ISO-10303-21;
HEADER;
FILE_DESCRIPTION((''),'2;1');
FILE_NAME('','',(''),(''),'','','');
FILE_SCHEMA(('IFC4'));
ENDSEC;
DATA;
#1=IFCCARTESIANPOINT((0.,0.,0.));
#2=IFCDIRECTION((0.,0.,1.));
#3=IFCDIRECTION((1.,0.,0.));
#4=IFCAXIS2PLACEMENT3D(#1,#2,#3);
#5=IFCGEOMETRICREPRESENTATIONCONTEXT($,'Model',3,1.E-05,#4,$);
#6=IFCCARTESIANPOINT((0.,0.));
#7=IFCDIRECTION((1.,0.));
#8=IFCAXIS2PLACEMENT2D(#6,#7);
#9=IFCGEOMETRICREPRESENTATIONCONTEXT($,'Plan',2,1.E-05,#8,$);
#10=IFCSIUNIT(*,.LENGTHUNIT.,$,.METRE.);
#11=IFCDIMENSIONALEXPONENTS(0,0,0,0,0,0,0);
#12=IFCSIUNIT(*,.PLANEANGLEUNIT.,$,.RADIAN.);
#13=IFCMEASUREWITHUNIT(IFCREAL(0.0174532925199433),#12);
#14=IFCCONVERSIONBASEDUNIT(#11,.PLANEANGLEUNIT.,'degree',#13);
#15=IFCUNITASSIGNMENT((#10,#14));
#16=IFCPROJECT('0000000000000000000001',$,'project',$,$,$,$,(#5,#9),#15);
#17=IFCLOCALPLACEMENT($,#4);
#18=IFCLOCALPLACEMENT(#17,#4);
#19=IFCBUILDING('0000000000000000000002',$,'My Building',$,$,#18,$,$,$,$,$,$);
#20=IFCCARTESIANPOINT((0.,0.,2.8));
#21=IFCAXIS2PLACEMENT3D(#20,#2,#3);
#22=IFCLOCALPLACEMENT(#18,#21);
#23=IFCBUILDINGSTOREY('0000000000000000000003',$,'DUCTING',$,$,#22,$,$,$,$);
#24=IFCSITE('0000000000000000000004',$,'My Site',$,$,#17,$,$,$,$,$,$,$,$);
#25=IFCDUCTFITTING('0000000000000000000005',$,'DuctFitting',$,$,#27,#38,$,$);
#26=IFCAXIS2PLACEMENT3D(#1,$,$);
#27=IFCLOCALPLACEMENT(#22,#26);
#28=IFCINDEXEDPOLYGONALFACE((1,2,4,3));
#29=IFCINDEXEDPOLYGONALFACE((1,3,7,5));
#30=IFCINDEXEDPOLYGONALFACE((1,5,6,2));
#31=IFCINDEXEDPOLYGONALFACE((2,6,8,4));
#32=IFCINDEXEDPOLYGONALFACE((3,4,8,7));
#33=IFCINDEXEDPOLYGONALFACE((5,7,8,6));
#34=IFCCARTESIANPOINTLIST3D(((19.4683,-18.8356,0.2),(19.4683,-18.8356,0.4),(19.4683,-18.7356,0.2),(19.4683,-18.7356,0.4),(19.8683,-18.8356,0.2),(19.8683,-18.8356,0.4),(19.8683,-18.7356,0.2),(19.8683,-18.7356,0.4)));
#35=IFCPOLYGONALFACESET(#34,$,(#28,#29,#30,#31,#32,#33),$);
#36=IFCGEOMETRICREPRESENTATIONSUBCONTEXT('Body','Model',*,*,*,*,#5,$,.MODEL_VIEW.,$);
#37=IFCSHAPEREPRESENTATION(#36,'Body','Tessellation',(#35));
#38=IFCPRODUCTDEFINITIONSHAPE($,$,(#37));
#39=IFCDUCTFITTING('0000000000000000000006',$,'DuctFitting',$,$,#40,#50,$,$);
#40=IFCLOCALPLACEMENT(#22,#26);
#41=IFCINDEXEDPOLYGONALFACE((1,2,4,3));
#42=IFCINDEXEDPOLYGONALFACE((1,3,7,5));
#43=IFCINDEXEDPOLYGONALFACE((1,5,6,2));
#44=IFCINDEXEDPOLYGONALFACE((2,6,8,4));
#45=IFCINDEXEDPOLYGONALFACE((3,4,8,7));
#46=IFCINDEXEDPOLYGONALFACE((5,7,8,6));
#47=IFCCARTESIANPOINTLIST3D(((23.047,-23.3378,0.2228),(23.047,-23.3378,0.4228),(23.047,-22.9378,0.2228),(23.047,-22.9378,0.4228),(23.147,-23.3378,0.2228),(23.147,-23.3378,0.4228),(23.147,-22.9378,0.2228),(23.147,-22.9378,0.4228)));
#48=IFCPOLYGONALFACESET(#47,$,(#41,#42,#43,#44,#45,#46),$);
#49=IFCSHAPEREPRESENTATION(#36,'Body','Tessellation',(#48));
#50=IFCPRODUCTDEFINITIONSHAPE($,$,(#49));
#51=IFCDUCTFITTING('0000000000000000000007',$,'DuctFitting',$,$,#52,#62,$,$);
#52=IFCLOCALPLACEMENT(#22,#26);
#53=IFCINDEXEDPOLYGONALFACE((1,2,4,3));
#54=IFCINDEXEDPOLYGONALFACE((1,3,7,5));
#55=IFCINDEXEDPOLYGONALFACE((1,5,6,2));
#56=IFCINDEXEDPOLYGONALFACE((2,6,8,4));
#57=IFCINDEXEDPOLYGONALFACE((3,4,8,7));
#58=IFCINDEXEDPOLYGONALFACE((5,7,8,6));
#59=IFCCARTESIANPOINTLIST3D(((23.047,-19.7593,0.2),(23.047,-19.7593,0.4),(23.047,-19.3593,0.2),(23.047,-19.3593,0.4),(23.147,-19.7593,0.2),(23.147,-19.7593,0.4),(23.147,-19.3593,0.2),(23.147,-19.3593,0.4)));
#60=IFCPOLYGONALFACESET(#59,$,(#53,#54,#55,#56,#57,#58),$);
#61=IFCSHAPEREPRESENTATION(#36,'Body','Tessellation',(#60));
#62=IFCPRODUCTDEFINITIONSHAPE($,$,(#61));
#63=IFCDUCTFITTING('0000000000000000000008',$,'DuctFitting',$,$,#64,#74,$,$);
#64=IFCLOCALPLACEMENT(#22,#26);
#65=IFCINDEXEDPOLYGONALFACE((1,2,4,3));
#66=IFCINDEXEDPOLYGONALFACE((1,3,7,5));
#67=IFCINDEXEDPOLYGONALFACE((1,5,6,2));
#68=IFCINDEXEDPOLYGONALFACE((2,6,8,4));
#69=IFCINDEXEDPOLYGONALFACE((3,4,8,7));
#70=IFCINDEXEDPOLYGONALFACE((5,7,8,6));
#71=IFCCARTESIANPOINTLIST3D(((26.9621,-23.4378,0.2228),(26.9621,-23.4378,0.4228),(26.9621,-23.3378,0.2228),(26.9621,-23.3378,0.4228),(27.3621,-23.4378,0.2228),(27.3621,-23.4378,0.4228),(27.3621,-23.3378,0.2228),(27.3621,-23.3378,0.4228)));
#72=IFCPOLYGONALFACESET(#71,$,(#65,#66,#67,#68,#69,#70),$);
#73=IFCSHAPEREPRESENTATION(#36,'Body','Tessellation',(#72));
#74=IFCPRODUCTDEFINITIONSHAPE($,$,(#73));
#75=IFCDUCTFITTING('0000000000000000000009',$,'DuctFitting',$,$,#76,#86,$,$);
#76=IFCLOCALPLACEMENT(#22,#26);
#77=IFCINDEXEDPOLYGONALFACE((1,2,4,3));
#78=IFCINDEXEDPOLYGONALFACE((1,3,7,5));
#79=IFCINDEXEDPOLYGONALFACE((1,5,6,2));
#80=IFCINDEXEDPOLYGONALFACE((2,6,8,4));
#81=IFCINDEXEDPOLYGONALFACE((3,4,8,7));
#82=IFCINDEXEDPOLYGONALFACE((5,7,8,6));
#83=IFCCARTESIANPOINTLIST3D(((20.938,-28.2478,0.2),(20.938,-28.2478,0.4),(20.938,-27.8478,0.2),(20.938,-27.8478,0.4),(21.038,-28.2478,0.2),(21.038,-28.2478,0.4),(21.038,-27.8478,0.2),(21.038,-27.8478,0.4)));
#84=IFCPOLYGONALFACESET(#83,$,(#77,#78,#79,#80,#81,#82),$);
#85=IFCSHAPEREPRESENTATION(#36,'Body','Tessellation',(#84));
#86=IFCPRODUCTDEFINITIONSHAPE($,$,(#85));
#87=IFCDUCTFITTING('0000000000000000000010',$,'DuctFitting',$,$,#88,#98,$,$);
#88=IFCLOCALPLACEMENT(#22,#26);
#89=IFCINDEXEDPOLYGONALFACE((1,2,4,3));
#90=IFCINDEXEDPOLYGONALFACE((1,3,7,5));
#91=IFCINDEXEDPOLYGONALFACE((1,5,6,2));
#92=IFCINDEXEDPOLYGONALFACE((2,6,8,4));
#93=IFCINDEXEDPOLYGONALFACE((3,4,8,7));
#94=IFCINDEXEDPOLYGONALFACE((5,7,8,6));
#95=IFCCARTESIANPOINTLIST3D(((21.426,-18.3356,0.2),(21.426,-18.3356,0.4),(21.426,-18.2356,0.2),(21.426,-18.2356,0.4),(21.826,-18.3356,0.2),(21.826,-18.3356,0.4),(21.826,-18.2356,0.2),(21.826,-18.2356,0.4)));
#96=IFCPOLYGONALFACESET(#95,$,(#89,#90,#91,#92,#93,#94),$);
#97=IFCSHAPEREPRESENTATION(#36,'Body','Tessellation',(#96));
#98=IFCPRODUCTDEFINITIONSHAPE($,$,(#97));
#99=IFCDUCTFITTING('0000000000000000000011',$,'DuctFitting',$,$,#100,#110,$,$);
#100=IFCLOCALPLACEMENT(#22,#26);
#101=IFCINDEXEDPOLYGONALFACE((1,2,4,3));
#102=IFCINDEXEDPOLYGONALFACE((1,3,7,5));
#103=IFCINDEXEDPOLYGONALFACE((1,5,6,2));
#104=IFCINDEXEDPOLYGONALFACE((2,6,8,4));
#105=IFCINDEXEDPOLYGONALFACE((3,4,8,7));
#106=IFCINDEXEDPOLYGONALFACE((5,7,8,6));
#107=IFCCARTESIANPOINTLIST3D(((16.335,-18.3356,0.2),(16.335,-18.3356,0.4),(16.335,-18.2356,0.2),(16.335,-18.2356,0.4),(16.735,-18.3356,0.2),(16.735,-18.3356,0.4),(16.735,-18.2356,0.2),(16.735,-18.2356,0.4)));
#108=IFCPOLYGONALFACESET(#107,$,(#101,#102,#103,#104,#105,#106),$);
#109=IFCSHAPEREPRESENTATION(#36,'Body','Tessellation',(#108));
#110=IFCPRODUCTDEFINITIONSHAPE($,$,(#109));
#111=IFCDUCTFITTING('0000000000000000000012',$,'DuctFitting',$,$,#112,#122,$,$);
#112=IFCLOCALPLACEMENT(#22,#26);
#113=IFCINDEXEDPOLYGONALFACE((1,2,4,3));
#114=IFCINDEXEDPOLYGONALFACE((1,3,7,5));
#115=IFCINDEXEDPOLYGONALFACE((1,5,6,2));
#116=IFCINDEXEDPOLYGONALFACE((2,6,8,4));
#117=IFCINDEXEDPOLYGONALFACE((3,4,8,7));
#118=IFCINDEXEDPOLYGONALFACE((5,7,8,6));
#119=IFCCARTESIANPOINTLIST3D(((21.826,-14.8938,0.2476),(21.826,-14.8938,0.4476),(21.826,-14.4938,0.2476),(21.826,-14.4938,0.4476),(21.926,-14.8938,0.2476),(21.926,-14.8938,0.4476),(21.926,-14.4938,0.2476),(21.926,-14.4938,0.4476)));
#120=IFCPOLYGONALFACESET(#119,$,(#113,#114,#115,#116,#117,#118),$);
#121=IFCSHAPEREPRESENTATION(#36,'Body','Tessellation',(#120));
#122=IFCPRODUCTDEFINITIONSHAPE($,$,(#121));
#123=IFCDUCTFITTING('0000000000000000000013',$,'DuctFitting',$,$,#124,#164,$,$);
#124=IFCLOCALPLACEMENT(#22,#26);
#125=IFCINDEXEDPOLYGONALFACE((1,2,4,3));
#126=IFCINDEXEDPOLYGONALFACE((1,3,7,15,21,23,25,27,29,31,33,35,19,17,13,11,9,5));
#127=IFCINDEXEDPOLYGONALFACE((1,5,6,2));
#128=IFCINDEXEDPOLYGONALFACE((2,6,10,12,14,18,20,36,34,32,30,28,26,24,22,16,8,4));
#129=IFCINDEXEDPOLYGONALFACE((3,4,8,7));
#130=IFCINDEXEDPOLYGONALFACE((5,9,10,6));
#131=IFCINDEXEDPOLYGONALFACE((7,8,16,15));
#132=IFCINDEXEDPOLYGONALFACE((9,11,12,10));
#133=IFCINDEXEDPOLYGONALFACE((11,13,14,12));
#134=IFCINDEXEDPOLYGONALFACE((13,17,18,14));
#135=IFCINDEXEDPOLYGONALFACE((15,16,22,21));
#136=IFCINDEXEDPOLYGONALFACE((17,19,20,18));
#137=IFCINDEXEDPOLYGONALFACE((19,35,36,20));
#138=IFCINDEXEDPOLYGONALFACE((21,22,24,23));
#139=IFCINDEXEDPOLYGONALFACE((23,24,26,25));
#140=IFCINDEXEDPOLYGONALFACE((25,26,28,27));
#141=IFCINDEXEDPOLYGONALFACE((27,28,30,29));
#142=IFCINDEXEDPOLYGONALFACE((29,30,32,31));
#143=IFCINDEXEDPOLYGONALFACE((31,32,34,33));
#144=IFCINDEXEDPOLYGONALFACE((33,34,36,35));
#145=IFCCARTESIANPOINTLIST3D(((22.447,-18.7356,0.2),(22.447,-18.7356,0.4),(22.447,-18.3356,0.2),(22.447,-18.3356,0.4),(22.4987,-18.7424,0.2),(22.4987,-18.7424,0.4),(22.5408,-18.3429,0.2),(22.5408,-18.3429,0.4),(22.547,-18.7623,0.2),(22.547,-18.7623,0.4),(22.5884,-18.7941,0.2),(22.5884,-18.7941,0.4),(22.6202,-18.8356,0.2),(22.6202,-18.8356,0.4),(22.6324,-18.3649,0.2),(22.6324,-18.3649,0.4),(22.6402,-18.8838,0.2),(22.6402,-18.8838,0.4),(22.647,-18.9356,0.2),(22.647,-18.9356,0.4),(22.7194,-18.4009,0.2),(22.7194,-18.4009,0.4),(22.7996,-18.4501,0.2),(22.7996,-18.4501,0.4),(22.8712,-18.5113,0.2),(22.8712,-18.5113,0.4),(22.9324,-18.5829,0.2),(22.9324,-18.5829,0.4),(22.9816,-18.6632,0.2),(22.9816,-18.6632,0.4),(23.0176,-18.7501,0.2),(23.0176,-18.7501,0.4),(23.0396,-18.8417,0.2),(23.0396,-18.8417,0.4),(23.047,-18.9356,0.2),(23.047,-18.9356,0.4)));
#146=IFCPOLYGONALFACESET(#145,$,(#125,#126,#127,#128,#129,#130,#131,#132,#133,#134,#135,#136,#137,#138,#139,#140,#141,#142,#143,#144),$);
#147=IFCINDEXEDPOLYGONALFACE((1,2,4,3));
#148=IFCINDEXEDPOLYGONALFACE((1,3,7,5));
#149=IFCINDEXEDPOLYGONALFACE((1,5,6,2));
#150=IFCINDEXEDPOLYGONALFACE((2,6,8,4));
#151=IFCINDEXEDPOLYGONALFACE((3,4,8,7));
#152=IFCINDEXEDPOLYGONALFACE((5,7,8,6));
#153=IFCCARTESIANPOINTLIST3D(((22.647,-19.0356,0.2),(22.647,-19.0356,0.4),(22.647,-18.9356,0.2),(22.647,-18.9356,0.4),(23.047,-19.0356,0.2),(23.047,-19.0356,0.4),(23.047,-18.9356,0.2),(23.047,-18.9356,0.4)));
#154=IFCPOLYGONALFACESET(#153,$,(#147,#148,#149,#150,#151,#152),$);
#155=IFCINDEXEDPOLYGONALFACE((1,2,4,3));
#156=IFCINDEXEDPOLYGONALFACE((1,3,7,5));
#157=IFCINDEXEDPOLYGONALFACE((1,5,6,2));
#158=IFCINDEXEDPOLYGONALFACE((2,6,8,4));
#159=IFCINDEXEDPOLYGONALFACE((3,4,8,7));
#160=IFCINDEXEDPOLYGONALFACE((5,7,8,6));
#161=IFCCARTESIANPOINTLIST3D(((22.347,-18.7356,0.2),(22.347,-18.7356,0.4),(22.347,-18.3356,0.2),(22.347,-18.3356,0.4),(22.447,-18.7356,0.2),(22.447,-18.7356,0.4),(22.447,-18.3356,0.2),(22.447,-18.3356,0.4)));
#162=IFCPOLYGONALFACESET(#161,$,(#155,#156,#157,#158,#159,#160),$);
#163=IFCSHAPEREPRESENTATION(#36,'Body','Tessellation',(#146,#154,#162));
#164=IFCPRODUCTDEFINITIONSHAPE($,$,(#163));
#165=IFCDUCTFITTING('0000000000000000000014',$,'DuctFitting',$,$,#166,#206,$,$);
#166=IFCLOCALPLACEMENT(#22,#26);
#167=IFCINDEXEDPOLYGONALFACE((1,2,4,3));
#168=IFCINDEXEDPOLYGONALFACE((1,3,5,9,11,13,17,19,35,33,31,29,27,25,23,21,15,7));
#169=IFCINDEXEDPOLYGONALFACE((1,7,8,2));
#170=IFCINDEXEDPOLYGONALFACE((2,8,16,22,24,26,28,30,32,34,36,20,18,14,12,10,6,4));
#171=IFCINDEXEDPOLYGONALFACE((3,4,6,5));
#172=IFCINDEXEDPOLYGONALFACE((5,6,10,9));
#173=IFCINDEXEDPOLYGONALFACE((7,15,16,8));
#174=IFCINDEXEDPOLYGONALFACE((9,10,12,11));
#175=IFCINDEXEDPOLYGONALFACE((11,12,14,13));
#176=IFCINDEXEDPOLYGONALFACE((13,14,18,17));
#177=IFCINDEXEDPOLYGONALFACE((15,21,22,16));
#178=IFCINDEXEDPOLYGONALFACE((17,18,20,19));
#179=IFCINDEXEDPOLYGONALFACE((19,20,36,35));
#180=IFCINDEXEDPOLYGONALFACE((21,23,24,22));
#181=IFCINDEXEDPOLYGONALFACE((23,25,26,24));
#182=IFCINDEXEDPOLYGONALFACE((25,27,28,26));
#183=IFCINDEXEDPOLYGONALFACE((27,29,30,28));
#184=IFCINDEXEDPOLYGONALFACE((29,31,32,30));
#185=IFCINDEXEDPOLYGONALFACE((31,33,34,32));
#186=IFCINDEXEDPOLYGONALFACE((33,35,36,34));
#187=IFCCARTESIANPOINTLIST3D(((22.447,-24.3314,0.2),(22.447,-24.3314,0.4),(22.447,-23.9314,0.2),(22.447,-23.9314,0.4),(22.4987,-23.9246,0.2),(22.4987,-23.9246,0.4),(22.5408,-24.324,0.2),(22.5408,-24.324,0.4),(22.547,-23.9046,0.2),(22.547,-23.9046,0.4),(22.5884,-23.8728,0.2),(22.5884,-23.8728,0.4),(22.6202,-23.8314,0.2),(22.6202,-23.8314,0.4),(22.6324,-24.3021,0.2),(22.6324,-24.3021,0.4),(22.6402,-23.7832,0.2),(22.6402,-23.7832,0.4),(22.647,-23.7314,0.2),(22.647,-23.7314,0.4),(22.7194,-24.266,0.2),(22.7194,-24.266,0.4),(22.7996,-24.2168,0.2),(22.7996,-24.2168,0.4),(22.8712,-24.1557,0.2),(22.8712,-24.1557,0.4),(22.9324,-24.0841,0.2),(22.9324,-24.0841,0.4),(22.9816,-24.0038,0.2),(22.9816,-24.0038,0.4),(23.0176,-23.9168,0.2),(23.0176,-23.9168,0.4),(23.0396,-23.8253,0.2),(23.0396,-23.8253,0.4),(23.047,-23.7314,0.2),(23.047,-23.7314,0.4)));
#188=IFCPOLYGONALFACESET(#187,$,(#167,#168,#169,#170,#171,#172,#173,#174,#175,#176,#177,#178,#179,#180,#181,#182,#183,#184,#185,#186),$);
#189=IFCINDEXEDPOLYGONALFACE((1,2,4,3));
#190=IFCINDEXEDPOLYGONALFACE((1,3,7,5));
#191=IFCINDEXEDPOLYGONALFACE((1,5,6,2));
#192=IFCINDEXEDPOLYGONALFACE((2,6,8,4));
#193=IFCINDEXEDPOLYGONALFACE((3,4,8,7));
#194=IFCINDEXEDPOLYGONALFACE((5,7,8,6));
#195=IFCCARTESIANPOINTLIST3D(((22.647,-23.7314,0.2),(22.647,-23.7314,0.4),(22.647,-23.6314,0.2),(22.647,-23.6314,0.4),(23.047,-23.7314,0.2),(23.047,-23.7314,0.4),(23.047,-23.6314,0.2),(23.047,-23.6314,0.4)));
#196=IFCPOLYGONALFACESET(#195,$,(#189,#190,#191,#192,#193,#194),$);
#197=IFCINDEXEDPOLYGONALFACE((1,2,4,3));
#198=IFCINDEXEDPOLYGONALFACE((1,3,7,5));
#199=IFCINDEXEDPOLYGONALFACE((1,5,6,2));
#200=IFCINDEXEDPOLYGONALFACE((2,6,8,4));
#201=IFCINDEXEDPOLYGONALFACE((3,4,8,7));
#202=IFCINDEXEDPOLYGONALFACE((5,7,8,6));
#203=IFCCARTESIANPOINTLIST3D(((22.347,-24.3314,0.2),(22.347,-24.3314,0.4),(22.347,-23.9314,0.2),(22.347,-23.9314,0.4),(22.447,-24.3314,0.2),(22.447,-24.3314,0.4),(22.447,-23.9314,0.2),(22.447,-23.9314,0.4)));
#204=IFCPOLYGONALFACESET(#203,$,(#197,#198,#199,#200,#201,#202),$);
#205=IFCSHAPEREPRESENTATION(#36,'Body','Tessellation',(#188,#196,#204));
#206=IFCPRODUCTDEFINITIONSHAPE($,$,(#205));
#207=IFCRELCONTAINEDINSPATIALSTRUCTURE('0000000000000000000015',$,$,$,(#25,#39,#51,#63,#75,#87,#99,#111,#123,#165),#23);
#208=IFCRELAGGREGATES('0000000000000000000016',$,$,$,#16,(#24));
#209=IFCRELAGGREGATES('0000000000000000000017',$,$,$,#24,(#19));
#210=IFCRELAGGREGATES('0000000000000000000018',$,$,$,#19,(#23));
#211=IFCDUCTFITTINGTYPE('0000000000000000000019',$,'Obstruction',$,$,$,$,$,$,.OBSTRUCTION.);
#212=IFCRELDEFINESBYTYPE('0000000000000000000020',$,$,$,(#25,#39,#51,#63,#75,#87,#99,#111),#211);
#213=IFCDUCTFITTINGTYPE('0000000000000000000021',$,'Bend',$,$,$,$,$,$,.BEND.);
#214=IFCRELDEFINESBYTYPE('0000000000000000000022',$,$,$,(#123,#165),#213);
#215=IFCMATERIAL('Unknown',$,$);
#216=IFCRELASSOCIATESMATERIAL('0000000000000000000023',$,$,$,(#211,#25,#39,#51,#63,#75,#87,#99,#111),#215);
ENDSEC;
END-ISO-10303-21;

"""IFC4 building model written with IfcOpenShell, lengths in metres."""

from ifc_helpers import new_model, entity, si_unit, converted_unit, frame, origin_with_axes, origin_2d_with_axis, place, context, subcontext, project, spatial, line, arc, indexed_curve, rectangle, outline, extrude, source, transform, mapped, material, material_profile, profile_set, profile_usage, type_object, type_shapes, element, save


model = new_model("IFC4")

# Units and contexts
model_context = context("Model", 3, precision=1e-05, world=origin_with_axes())
plan_context = context("Plan", 2, precision=1e-05, world=origin_2d_with_axis())
body_context = subcontext(model_context, "Body", "Model", "MODEL_VIEW")
ifc_project = project(units=[si_unit("LENGTHUNIT", "METRE"), converted_unit("PLANEANGLEUNIT", "degree", entity("IfcReal", 0.0174532925199433), si_unit("PLANEANGLEUNIT", "RADIAN"), dimensions=[0, 0, 0, 0, 0, 0, 0])], contexts=[model_context, plan_context])

# Site, building, storey
site_placement = place(None, origin_with_axes())
site = spatial("IfcSite", under=ifc_project, at=site_placement, Name="My Site")
building_placement = place(site_placement, origin_with_axes())
building = spatial("IfcBuilding", under=site, at=building_placement, Name="My Building")
storey_placement = place(building_placement, frame((0.0, 0.0, 2.8), z_axis=(0.0, 0.0, 1.0), x_axis=(1.0, 0.0, 0.0)))
storey = spatial("IfcBuildingStorey", under=building, at=storey_placement, Name="DUCTING")

# Shared definitions
ifc_material = material(Name="Unknown")

# Duct fittings
ifc_material_profile_1 = material_profile(ifc_material, rectangle(XDim=0.4, YDim=0.2))
ifc_profile_set_1 = profile_set([ifc_material_profile_1])
duct_fitting_type_1 = type_object("IfcDuctFittingType", Name="Obstruction", PredefinedType="OBSTRUCTION", material=ifc_profile_set_1)
ifc_profile_usage_1 = profile_usage(ifc_profile_set_1, cardinal=5)
duct_fitting_1_placement = place(storey_placement, frame((19.6683, -18.7356, 0.3), z_axis=(0.0, -1.0, 0.0), x_axis=(1.0, 0.0, 0.0)))
element("IfcDuctFitting", 1, at=duct_fitting_1_placement, inside=storey, type_object=duct_fitting_type_1, material=ifc_profile_usage_1, Name="DuctFitting", context=body_context, shape_type="SweptSolid", body=[
    extrude(rectangle(XDim=0.4, YDim=0.2), origin_with_axes(), (0.0, 0.0, 1.0), 0.1),
])
ifc_profile_usage_2 = profile_usage(ifc_profile_set_1, cardinal=5)
duct_fitting_2_placement = place(storey_placement, frame((23.047, -23.1378, 0.3228), z_axis=(1.0, 0.0, 0.0), x_axis=(0.0, 1.0, 0.0)))
element("IfcDuctFitting", 2, at=duct_fitting_2_placement, inside=storey, type_object=duct_fitting_type_1, material=ifc_profile_usage_2, Name="DuctFitting", context=body_context, shape_type="SweptSolid", body=[
    extrude(rectangle(XDim=0.4, YDim=0.2), origin_with_axes(), (0.0, 0.0, 1.0), 0.1),
])
ifc_profile_usage_3 = profile_usage(ifc_profile_set_1, cardinal=5)
duct_fitting_3_placement = place(storey_placement, frame((23.047, -19.5593, 0.3), z_axis=(1.0, 0.0, 0.0), x_axis=(0.0, 1.0, 0.0)))
element("IfcDuctFitting", 3, at=duct_fitting_3_placement, inside=storey, type_object=duct_fitting_type_1, material=ifc_profile_usage_3, Name="DuctFitting", context=body_context, shape_type="SweptSolid", body=[
    extrude(rectangle(XDim=0.4, YDim=0.2), origin_with_axes(), (0.0, 0.0, 1.0), 0.1),
])
ifc_profile_usage_4 = profile_usage(ifc_profile_set_1, cardinal=5)
duct_fitting_4_placement = place(storey_placement, frame((27.1621, -23.3378, 0.3228), z_axis=(0.0, -1.0, 0.0), x_axis=(1.0, 0.0, 0.0)))
element("IfcDuctFitting", 4, at=duct_fitting_4_placement, inside=storey, type_object=duct_fitting_type_1, material=ifc_profile_usage_4, Name="DuctFitting", context=body_context, shape_type="SweptSolid", body=[
    extrude(rectangle(XDim=0.4, YDim=0.2), origin_with_axes(), (0.0, 0.0, 1.0), 0.1),
])
ifc_profile_usage_5 = profile_usage(ifc_profile_set_1, cardinal=5)
duct_fitting_5_placement = place(storey_placement, frame((20.938, -28.0478, 0.3), z_axis=(1.0, 0.0, 0.0), x_axis=(0.0, 1.0, 0.0)))
element("IfcDuctFitting", 5, at=duct_fitting_5_placement, inside=storey, type_object=duct_fitting_type_1, material=ifc_profile_usage_5, Name="DuctFitting", context=body_context, shape_type="SweptSolid", body=[
    extrude(rectangle(XDim=0.4, YDim=0.2), origin_with_axes(), (0.0, 0.0, 1.0), 0.1),
])
ifc_profile_usage_6 = profile_usage(ifc_profile_set_1, cardinal=5)
duct_fitting_6_placement = place(storey_placement, frame((21.626, -18.2356, 0.3), z_axis=(0.0, -1.0, 0.0), x_axis=(1.0, 0.0, 0.0)))
element("IfcDuctFitting", 6, at=duct_fitting_6_placement, inside=storey, type_object=duct_fitting_type_1, material=ifc_profile_usage_6, Name="DuctFitting", context=body_context, shape_type="SweptSolid", body=[
    extrude(rectangle(XDim=0.4, YDim=0.2), origin_with_axes(), (0.0, 0.0, 1.0), 0.1),
])
ifc_profile_usage_7 = profile_usage(ifc_profile_set_1, cardinal=5)
duct_fitting_7_placement = place(storey_placement, frame((16.535, -18.2356, 0.3), z_axis=(0.0, -1.0, 0.0), x_axis=(1.0, 0.0, 0.0)))
element("IfcDuctFitting", 7, at=duct_fitting_7_placement, inside=storey, type_object=duct_fitting_type_1, material=ifc_profile_usage_7, Name="DuctFitting", context=body_context, shape_type="SweptSolid", body=[
    extrude(rectangle(XDim=0.4, YDim=0.2), origin_with_axes(), (0.0, 0.0, 1.0), 0.1),
])
ifc_profile_usage_8 = profile_usage(ifc_profile_set_1, cardinal=5)
duct_fitting_8_placement = place(storey_placement, frame((21.826, -14.6938, 0.3476), z_axis=(1.0, 0.0, 0.0), x_axis=(0.0, 1.0, 0.0)))
element("IfcDuctFitting", 8, at=duct_fitting_8_placement, inside=storey, type_object=duct_fitting_type_1, material=ifc_profile_usage_8, Name="DuctFitting", context=body_context, shape_type="SweptSolid", body=[
    extrude(rectangle(XDim=0.4, YDim=0.2), origin_with_axes(), (0.0, 0.0, 1.0), 0.1),
])
duct_fitting_type_2 = type_object("IfcDuctFittingType", Name="Bend", PredefinedType="BEND")
shared_shape = source(origin_with_axes(), body_context, "Body", "SweptSolid", [
    extrude(outline(indexed_curve([(0.2, 0.0), (0.2586, -0.1414), (0.4, -0.2), (0.4, -0.6), (-0.0243, -0.4243), (-0.2, 0.0)], segments=[arc(1, 2, 3), line(3, 4), arc(4, 5, 6), line(6, 1)])), frame((0.0, -0.1, -0.1), z_axis=(0.0, -1.0, 0.0), x_axis=(1.0, 0.0, 0.0)), (0.0, 0.0, -1.0), 0.2),
    extrude(rectangle(XDim=0.4, YDim=0.2), origin_with_axes(), (0.0, 0.0, -1.0), 0.1),
    extrude(rectangle(XDim=0.4, YDim=0.2), frame((0.4, 0.0, -0.5), z_axis=(1.0, 0.0, 0.0), x_axis=(0.0, 0.0, 1.0)), (0.0, 0.0, 1.0), 0.1),
])
type_shapes(duct_fitting_type_2, [shared_shape])
for number, where, z_axis, x_axis, name in (
    (9, (22.847, -19.0356, 0.3), (0.0, -1.0, -0.000001), (-1.0, 0.0, 0.0), "DuctFitting"),
    (10, (22.847, -23.6314, 0.3), (0.0, 1.0, 0.000001), (-1.0, 0.0, 0.0), "DuctFitting"),
):
    element("IfcDuctFitting", number, at=place(storey_placement, frame(where, z_axis=z_axis, x_axis=x_axis)), inside=storey, type_object=duct_fitting_type_2, Name=name, context=body_context, shape_type="MappedRepresentation", body=[
        mapped(shared_shape, transform((0.0, 0.0, 0.0), x_axis=(1.0, 0.0, 0.0), y_axis=(0.0, 1.0, 0.0), z_axis=(0.0, 0.0, 1.0), scale=1.0)),
    ])

save(model, "model.ifc")
